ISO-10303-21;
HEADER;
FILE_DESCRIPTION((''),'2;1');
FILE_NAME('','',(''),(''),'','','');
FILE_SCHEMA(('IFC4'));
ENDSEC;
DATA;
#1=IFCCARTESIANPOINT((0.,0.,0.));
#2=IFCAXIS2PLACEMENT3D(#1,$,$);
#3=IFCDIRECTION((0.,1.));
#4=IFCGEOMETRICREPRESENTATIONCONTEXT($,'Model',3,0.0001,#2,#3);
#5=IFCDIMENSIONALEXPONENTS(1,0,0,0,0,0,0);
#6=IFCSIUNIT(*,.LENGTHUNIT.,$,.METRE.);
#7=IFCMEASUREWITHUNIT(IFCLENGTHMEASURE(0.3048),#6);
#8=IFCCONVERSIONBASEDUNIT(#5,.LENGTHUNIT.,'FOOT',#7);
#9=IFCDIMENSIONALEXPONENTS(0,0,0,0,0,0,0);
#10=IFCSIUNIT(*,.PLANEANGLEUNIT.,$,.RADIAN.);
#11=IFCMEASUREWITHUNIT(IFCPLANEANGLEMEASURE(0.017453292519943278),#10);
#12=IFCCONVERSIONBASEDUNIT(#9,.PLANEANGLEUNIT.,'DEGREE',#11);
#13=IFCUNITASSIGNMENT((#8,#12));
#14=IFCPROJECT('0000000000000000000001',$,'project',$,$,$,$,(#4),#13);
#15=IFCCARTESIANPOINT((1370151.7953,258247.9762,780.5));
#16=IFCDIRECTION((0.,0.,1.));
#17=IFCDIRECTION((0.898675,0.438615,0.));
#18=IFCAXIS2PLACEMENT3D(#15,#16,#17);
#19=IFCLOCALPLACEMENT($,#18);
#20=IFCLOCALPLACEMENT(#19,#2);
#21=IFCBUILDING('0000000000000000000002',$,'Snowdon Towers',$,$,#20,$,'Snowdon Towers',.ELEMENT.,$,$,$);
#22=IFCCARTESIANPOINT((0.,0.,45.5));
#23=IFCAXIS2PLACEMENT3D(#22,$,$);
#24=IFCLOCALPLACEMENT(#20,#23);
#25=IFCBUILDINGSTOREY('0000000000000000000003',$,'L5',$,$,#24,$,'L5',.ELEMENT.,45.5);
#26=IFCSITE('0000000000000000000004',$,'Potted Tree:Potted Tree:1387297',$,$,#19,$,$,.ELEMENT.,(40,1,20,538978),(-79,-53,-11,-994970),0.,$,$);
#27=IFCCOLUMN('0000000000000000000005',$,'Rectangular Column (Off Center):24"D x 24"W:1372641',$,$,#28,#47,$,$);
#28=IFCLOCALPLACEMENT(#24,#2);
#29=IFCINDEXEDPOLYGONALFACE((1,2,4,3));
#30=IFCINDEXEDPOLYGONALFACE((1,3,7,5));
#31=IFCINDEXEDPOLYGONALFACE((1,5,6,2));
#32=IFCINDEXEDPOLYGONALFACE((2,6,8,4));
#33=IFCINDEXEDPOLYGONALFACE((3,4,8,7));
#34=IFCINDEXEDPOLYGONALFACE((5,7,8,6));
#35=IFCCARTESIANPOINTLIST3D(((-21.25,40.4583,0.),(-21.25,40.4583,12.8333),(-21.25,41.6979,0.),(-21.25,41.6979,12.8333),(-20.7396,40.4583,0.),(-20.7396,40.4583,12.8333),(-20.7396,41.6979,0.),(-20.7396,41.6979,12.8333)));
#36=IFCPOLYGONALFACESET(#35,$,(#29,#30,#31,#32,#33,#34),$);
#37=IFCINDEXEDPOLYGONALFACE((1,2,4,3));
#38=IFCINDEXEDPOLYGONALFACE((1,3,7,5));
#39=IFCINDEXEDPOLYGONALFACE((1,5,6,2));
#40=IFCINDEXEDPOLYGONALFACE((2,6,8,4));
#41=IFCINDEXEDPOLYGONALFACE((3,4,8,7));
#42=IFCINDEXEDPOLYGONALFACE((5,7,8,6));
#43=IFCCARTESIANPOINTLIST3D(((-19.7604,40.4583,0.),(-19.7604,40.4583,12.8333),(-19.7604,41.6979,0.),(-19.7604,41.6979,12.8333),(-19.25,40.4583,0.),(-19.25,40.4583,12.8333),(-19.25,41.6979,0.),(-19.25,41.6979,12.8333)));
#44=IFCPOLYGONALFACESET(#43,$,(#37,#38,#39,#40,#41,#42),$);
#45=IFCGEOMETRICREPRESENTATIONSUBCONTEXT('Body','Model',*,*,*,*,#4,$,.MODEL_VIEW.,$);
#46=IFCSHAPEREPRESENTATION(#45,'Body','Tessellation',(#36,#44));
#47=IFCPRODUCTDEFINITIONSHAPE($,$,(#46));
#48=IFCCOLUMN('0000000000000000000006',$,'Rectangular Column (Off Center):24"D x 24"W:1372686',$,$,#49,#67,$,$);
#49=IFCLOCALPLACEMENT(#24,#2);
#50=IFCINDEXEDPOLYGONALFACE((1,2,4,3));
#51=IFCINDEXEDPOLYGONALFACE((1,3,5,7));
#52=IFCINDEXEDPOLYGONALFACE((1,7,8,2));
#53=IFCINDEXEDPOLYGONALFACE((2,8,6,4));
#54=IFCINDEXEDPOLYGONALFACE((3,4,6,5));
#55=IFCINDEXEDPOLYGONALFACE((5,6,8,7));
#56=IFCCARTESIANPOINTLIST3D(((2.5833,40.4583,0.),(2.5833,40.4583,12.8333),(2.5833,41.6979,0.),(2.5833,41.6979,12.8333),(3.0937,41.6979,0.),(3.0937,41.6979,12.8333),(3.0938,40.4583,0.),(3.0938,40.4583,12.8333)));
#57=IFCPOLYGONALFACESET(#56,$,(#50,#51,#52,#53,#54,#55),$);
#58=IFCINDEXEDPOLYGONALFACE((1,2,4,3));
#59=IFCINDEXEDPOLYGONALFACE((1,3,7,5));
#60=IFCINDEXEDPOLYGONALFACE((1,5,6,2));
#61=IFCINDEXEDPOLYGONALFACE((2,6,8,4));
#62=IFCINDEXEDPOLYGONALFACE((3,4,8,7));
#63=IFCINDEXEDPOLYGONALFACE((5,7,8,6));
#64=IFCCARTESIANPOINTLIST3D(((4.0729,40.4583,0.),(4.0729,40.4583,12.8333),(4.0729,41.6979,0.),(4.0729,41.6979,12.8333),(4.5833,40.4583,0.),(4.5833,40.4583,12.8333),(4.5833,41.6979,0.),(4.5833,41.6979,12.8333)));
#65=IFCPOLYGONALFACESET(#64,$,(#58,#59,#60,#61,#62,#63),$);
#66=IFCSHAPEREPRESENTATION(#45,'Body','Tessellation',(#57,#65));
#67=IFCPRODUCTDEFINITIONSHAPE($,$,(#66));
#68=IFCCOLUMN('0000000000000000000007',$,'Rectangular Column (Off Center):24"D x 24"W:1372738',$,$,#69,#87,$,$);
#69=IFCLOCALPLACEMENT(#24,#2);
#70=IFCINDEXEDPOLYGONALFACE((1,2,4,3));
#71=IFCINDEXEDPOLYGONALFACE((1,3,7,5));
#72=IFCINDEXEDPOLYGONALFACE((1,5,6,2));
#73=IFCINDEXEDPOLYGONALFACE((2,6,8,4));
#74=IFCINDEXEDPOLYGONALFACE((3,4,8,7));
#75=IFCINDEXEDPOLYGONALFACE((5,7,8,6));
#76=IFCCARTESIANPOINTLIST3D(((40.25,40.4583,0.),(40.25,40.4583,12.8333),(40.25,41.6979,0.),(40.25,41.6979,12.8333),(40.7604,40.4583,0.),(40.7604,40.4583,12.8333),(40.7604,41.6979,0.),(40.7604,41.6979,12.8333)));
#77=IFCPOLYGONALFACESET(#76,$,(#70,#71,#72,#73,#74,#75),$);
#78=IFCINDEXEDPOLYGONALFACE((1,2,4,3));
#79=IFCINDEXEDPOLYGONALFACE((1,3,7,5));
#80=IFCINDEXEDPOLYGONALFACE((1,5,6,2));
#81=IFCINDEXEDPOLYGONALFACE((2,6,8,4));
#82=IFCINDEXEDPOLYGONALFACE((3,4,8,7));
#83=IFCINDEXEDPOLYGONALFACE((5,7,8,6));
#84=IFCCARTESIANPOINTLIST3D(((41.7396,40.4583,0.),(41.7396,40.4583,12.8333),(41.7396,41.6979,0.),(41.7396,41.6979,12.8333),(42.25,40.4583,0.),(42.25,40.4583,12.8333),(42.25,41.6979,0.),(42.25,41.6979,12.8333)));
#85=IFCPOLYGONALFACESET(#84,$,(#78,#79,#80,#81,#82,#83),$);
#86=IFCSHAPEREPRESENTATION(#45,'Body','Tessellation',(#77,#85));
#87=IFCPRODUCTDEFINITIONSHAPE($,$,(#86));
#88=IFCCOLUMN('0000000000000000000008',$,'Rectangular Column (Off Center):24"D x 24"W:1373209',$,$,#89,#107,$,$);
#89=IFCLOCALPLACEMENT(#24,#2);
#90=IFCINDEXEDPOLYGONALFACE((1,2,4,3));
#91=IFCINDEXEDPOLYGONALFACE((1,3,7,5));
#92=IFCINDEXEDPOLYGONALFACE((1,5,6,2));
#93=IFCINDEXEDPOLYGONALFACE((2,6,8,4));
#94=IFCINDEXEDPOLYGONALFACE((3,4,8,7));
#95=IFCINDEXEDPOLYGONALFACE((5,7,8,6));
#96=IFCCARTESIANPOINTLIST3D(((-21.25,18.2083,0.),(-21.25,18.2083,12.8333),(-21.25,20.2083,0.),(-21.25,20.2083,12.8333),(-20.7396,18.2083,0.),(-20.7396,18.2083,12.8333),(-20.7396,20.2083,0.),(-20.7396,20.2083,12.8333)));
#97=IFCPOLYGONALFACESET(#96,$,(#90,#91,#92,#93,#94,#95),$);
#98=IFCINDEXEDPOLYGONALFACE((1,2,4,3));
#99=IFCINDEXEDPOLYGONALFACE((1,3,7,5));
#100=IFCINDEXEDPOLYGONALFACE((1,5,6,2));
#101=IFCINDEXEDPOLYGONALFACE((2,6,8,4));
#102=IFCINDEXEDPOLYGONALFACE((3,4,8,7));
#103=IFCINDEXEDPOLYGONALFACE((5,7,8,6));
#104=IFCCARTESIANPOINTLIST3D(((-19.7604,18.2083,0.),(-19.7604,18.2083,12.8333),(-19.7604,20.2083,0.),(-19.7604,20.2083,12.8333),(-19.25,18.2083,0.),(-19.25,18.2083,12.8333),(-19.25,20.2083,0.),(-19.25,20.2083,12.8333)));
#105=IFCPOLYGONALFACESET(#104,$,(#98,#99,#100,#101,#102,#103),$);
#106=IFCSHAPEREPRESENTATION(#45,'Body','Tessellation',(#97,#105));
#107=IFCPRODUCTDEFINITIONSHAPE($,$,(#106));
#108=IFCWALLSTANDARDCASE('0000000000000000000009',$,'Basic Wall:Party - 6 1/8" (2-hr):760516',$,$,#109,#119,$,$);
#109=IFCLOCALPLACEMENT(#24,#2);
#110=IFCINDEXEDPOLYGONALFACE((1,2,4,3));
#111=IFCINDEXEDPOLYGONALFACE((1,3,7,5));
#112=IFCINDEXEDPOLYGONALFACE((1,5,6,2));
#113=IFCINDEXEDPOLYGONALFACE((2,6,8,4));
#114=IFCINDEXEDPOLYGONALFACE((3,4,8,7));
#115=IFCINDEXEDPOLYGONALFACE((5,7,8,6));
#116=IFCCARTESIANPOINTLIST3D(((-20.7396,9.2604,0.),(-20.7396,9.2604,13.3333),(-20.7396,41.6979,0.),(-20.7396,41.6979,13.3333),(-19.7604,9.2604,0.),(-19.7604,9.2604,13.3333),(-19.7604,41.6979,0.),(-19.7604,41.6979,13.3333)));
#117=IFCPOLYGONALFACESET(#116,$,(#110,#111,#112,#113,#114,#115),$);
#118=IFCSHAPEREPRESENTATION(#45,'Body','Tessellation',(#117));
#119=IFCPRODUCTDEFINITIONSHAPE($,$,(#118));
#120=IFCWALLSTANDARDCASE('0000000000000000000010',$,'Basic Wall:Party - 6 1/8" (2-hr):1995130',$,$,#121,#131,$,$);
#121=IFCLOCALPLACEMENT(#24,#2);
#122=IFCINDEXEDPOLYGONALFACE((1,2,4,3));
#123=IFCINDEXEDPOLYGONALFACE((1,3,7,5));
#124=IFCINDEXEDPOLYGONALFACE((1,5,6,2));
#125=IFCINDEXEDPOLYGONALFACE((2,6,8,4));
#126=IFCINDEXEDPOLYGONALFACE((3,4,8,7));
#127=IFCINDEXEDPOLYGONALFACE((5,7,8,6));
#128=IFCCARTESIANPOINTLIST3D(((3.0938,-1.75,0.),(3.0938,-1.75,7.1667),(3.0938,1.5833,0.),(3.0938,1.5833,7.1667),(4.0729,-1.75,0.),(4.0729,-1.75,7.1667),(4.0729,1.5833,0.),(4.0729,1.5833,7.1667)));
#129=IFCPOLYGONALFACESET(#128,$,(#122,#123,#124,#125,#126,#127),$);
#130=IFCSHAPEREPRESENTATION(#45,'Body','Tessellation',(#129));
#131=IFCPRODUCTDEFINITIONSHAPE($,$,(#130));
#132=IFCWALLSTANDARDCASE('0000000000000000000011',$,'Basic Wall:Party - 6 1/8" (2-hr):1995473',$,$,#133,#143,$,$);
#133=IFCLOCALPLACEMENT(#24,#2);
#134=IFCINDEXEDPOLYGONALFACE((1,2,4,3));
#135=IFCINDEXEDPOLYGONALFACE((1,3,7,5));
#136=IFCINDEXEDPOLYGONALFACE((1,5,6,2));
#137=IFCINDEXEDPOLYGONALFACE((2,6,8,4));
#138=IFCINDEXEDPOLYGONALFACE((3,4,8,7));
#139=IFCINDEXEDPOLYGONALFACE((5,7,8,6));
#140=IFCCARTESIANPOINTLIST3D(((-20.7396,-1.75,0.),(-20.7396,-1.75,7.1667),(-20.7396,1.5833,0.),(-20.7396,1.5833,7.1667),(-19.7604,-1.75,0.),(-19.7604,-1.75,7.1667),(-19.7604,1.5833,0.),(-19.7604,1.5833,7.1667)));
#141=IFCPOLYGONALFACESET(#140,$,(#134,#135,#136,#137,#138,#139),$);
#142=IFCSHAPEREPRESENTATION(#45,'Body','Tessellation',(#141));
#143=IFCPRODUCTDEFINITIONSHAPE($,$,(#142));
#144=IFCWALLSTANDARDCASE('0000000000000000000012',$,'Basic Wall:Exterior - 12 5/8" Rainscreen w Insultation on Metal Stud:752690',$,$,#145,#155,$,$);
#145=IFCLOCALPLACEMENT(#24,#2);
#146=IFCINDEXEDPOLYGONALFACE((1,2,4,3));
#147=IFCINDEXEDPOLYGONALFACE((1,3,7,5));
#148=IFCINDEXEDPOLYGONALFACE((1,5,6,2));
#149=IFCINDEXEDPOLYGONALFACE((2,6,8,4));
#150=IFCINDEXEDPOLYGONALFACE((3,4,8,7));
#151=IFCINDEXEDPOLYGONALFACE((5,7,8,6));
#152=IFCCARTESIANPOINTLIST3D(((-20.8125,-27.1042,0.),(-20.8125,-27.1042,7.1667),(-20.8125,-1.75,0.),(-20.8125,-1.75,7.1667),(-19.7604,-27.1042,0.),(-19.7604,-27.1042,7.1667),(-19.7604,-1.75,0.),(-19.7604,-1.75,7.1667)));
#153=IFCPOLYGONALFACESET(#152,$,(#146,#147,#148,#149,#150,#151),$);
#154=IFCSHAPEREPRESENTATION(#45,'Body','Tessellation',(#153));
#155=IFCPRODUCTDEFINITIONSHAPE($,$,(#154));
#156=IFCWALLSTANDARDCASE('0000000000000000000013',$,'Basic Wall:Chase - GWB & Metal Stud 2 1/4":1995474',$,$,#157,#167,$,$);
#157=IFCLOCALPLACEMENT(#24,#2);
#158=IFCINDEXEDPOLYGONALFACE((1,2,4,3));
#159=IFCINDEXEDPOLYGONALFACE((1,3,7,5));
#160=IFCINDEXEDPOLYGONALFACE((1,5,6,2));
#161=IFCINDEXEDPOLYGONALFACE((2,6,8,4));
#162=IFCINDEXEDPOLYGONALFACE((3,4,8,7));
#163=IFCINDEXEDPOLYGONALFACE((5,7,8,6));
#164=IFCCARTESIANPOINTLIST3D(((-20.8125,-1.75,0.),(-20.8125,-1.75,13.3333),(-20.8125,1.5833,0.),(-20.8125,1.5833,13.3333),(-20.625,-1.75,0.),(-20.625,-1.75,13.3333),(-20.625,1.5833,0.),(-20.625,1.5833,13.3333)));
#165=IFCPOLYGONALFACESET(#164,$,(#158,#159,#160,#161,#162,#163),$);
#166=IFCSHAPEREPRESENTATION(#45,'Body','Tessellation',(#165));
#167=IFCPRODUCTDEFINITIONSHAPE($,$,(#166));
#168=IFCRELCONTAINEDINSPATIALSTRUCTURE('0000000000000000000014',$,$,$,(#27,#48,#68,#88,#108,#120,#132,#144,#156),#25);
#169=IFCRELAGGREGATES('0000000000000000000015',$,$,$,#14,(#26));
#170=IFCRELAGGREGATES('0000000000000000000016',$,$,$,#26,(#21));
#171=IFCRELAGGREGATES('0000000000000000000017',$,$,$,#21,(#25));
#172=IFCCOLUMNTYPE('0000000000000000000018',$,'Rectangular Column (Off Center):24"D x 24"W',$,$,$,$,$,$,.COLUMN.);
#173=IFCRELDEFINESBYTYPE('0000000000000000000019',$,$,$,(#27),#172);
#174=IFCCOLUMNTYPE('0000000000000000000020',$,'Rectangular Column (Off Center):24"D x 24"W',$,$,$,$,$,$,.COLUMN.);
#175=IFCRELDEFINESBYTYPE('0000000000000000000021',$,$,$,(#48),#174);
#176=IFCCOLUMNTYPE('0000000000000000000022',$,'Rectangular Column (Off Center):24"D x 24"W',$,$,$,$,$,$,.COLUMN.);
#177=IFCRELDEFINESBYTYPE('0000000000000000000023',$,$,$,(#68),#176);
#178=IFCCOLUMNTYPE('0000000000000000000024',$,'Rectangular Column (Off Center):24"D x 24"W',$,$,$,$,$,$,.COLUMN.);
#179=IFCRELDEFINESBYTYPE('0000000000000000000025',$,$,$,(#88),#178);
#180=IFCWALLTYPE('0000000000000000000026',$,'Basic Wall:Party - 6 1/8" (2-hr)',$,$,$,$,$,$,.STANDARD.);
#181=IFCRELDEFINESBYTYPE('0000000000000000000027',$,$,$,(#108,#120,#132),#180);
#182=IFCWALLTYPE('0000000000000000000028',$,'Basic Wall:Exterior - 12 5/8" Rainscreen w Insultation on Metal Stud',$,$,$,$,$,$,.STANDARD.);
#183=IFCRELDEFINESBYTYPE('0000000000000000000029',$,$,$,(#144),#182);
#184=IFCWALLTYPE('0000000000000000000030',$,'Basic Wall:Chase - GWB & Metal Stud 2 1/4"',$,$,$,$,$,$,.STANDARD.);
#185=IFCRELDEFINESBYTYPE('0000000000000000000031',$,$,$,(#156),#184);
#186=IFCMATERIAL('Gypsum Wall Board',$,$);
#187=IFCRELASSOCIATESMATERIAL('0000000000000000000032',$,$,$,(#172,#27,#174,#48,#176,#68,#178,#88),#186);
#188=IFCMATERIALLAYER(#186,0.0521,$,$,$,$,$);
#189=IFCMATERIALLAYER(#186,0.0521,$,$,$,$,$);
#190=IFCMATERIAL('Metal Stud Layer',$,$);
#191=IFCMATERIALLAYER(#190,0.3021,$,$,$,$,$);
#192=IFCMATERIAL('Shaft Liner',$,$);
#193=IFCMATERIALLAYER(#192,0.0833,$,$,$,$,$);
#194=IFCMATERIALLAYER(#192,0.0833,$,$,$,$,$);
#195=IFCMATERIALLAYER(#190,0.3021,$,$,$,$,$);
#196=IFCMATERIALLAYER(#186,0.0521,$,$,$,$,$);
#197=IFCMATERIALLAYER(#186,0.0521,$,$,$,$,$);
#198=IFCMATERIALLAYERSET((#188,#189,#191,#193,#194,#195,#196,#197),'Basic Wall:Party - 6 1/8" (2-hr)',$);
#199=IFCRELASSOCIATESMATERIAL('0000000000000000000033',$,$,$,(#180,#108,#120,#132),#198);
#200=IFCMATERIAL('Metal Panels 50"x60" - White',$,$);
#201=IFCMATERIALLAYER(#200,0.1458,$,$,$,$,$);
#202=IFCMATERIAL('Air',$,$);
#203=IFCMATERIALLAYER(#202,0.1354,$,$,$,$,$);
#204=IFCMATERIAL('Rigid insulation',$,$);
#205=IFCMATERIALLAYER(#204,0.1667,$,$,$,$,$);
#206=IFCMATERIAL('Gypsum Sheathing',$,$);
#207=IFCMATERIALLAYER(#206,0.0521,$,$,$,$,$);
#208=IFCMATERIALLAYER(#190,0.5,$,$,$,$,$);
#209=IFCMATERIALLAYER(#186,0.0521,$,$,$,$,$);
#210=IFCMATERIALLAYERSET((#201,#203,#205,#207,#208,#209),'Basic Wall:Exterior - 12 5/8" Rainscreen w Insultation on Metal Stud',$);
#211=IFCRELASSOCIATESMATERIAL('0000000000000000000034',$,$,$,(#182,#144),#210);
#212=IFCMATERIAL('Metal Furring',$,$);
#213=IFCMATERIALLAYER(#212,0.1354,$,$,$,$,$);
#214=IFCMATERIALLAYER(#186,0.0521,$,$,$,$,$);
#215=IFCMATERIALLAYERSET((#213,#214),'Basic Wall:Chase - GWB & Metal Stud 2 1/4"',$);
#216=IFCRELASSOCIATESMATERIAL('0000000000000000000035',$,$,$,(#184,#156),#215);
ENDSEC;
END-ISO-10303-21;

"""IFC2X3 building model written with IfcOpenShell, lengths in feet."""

from ifc_helpers import new_model, entity, si_unit, converted_unit, direction, frame, frame_2d, origin, place, context, subcontext, project, spatial, rectangle, extrude, source, transform, mapped, material, layer, layer_set, layer_usage, type_object, type_shapes, element, save


model = new_model("IFC2X3")

# Units and contexts
model_context = context("Model", 3, precision=0.0001, world=origin(), true_north=direction((0.0, 1.0)))
body_context = subcontext(model_context, "Body", "Model", "MODEL_VIEW")
ifc_project = project(units=[converted_unit("LENGTHUNIT", "FOOT", entity("IfcLengthMeasure", 0.3048), si_unit("LENGTHUNIT", "METRE"), dimensions=[1, 0, 0, 0, 0, 0, 0]), converted_unit("PLANEANGLEUNIT", "DEGREE", entity("IfcPlaneAngleMeasure", 0.017453292519943278), si_unit("PLANEANGLEUNIT", "RADIAN"), dimensions=[0, 0, 0, 0, 0, 0, 0])], contexts=[model_context])

# Site, building, storey
site_placement = place(None, frame((1370151.7953, 258247.9762, 780.5), z_axis=(0.0, 0.0, 1.0), x_axis=(0.898675, 0.438615, 0.0)))
site = spatial("IfcSite", under=ifc_project, at=site_placement, Name="Potted Tree:Potted Tree:1387297", CompositionType="ELEMENT", RefLatitude=(40, 1, 20, 538978), RefLongitude=(-79, -53, -11, -994970), RefElevation=0.0)
building_placement = place(site_placement, origin())
building = spatial("IfcBuilding", under=site, at=building_placement, Name="Snowdon Towers", LongName="Snowdon Towers", CompositionType="ELEMENT")
storey_placement = place(building_placement, frame((0.0, 0.0, 45.5)))
storey = spatial("IfcBuildingStorey", under=building, at=storey_placement, Name="L5", LongName="L5", CompositionType="ELEMENT", Elevation=45.5)

# Shared definitions
ifc_material_1 = material(Name="Gypsum Wall Board")

# Columns
column_type_1 = type_object("IfcColumnType", Name="Rectangular Column (Off Center):24\"D x 24\"W", PredefinedType="COLUMN", material=ifc_material_1)
shared_shape_1 = source(origin(), body_context, "Body", "SweptSolid", [
    extrude(rectangle(XDim=1.2396, YDim=0.5104, at=frame_2d((0.0, 0.0), x_axis=(1.0, 0.0))), frame((-20.9948, 41.0781, 45.5), z_axis=(0.0, 0.0, 1.0), x_axis=(0.0, 1.0, 0.0)), (0.0, 0.0, 1.0), 12.8333),
    extrude(rectangle(XDim=1.2396, YDim=0.5104, at=frame_2d((0.0, 0.0), x_axis=(1.0, 0.0))), frame((-19.5052, 41.0781, 45.5), z_axis=(0.0, 0.0, 1.0), x_axis=(0.0, 1.0, 0.0)), (0.0, 0.0, 1.0), 12.8333),
])
type_shapes(column_type_1, [shared_shape_1])
column_1_placement = place(storey_placement, frame((0.0, 0.0, -45.5)))
element("IfcColumn", 1, at=column_1_placement, inside=storey, type_object=column_type_1, material=ifc_material_1, Name="Rectangular Column (Off Center):24\"D x 24\"W:1372641", context=body_context, shape_type="MappedRepresentation", body=[
    mapped(shared_shape_1, transform((0.0, 0.0, 0.0), scale=1.0)),
])
column_type_2 = type_object("IfcColumnType", Name="Rectangular Column (Off Center):24\"D x 24\"W", PredefinedType="COLUMN", material=ifc_material_1)
shared_shape_2 = source(origin(), body_context, "Body", "SweptSolid", [
    extrude(rectangle(XDim=0.5104, YDim=1.2396, at=frame_2d((0.0, 0.0), x_axis=(1.0, 0.0))), frame((2.8385, 41.0781, 45.5)), (0.0, 0.0, 1.0), 12.8333),
    extrude(rectangle(XDim=0.5104, YDim=1.2396, at=frame_2d((0.0, 0.0), x_axis=(1.0, 0.0))), frame((4.3281, 41.0781, 45.5), z_axis=(0.0, 0.0, 1.0), x_axis=(-1.0, 0.0, 0.0)), (0.0, 0.0, 1.0), 12.8333),
])
type_shapes(column_type_2, [shared_shape_2])
column_2_placement = place(storey_placement, frame((0.0, 0.0, -45.5)))
element("IfcColumn", 2, at=column_2_placement, inside=storey, type_object=column_type_2, material=ifc_material_1, Name="Rectangular Column (Off Center):24\"D x 24\"W:1372686", context=body_context, shape_type="MappedRepresentation", body=[
    mapped(shared_shape_2, transform((0.0, 0.0, 0.0), scale=1.0)),
])
column_type_3 = type_object("IfcColumnType", Name="Rectangular Column (Off Center):24\"D x 24\"W", PredefinedType="COLUMN", material=ifc_material_1)
shared_shape_3 = source(origin(), body_context, "Body", "SweptSolid", [
    extrude(rectangle(XDim=1.2396, YDim=0.5104, at=frame_2d((0.0, 0.0), x_axis=(1.0, 0.0))), frame((40.5052, 41.0781, 45.5), z_axis=(0.0, 0.0, 1.0), x_axis=(0.0, 1.0, 0.0)), (0.0, 0.0, 1.0), 12.8333),
    extrude(rectangle(XDim=1.2396, YDim=0.5104, at=frame_2d((0.0, 0.0), x_axis=(1.0, 0.0))), frame((41.9948, 41.0781, 45.5), z_axis=(0.0, 0.0, 1.0), x_axis=(0.0, 1.0, 0.0)), (0.0, 0.0, 1.0), 12.8333),
])
type_shapes(column_type_3, [shared_shape_3])
column_3_placement = place(storey_placement, frame((0.0, 0.0, -45.5)))
element("IfcColumn", 3, at=column_3_placement, inside=storey, type_object=column_type_3, material=ifc_material_1, Name="Rectangular Column (Off Center):24\"D x 24\"W:1372738", context=body_context, shape_type="MappedRepresentation", body=[
    mapped(shared_shape_3, transform((0.0, 0.0, 0.0), scale=1.0)),
])
column_type_4 = type_object("IfcColumnType", Name="Rectangular Column (Off Center):24\"D x 24\"W", PredefinedType="COLUMN", material=ifc_material_1)
shared_shape_4 = source(origin(), body_context, "Body", "SweptSolid", [
    extrude(rectangle(XDim=0.5104, YDim=2.0, at=frame_2d((0.0, 0.0), x_axis=(1.0, 0.0))), frame((-20.9948, 19.2083, 45.5)), (0.0, 0.0, 1.0), 12.8333),
    extrude(rectangle(XDim=0.5104, YDim=2.0, at=frame_2d((0.0, 0.0), x_axis=(1.0, 0.0))), frame((-19.5052, 19.2083, 45.5), z_axis=(0.0, 0.0, 1.0), x_axis=(-1.0, 0.0, 0.0)), (0.0, 0.0, 1.0), 12.8333),
])
type_shapes(column_type_4, [shared_shape_4])
column_4_placement = place(storey_placement, frame((0.0, 0.0, -45.5)))
element("IfcColumn", 4, at=column_4_placement, inside=storey, type_object=column_type_4, material=ifc_material_1, Name="Rectangular Column (Off Center):24\"D x 24\"W:1373209", context=body_context, shape_type="MappedRepresentation", body=[
    mapped(shared_shape_4, transform((0.0, 0.0, 0.0), scale=1.0)),
])

# Walls
ifc_layer_1 = layer(ifc_material_1, 0.0521)
ifc_layer_2 = layer(ifc_material_1, 0.0521)
ifc_material_2 = material(Name="Metal Stud Layer")
ifc_layer_3 = layer(ifc_material_2, 0.3021)
ifc_material_3 = material(Name="Shaft Liner")
ifc_layer_4 = layer(ifc_material_3, 0.0833)
ifc_layer_5 = layer(ifc_material_3, 0.0833)
ifc_layer_6 = layer(ifc_material_2, 0.3021)
ifc_layer_7 = layer(ifc_material_1, 0.0521)
ifc_layer_8 = layer(ifc_material_1, 0.0521)
ifc_layer_set_1 = layer_set([ifc_layer_1, ifc_layer_2, ifc_layer_3, ifc_layer_4, ifc_layer_5, ifc_layer_6, ifc_layer_7, ifc_layer_8], Name="Basic Wall:Party - 6 1/8\" (2-hr)")
ifc_layer_usage_1 = layer_usage(ifc_layer_set_1, "AXIS2", "NEGATIVE", 0.4896)
wall_type_1 = type_object("IfcWallType", Name="Basic Wall:Party - 6 1/8\" (2-hr)", PredefinedType="STANDARD", material=ifc_layer_set_1)
wall_1_placement = place(storey_placement, frame((-20.25, 9.2604, 0.0), z_axis=(0.0, 0.0, 1.0), x_axis=(0.0, 1.0, 0.0)))
element("IfcWallStandardCase", 5, at=wall_1_placement, inside=storey, type_object=wall_type_1, material=ifc_layer_usage_1, Name="Basic Wall:Party - 6 1/8\" (2-hr):760516", context=body_context, shape_type="SweptSolid", body=[
    extrude(rectangle(XDim=32.4375, YDim=0.9792, at=frame_2d((16.2188, 0.0), x_axis=(-1.0, 0.0))), origin(), (0.0, 0.0, 1.0), 13.3333),
])
ifc_layer_usage_2 = layer_usage(ifc_layer_set_1, "AXIS2", "POSITIVE", -0.4896)
wall_2_placement = place(storey_placement, frame((3.5833, -1.75, 0.0), z_axis=(0.0, 0.0, 1.0), x_axis=(0.0, 1.0, 0.0)))
element("IfcWallStandardCase", 6, at=wall_2_placement, inside=storey, type_object=wall_type_1, material=ifc_layer_usage_2, Name="Basic Wall:Party - 6 1/8\" (2-hr):1995130", context=body_context, shape_type="SweptSolid", body=[
    extrude(rectangle(XDim=3.3333, YDim=0.9792, at=frame_2d((1.6667, 0.0), x_axis=(-1.0, 0.0))), origin(), (0.0, 0.0, 1.0), 7.1667),
])
ifc_layer_usage_3 = layer_usage(ifc_layer_set_1, "AXIS2", "NEGATIVE", 0.4896)
wall_3_placement = place(storey_placement, frame((-20.25, -1.75, 0.0), z_axis=(0.0, 0.0, 1.0), x_axis=(0.0, 1.0, 0.0)))
element("IfcWallStandardCase", 7, at=wall_3_placement, inside=storey, type_object=wall_type_1, material=ifc_layer_usage_3, Name="Basic Wall:Party - 6 1/8\" (2-hr):1995473", context=body_context, shape_type="SweptSolid", body=[
    extrude(rectangle(XDim=3.3333, YDim=0.9792, at=frame_2d((1.6667, 0.0), x_axis=(-1.0, 0.0))), origin(), (0.0, 0.0, 1.0), 7.1667),
])
ifc_material_4 = material(Name="Metal Panels 50\"x60\" - White")
ifc_layer_9 = layer(ifc_material_4, 0.1458)
ifc_material_5 = material(Name="Air")
ifc_layer_10 = layer(ifc_material_5, 0.1354)
ifc_material_6 = material(Name="Rigid insulation")
ifc_layer_11 = layer(ifc_material_6, 0.1667)
ifc_material_7 = material(Name="Gypsum Sheathing")
ifc_layer_12 = layer(ifc_material_7, 0.0521)
ifc_layer_13 = layer(ifc_material_2, 0.5)
ifc_layer_14 = layer(ifc_material_1, 0.0521)
ifc_layer_set_2 = layer_set([ifc_layer_9, ifc_layer_10, ifc_layer_11, ifc_layer_12, ifc_layer_13, ifc_layer_14], Name="Basic Wall:Exterior - 12 5/8\" Rainscreen w Insultation on Metal Stud")
ifc_layer_usage_4 = layer_usage(ifc_layer_set_2, "AXIS2", "NEGATIVE", 0.526)
wall_type_2 = type_object("IfcWallType", Name="Basic Wall:Exterior - 12 5/8\" Rainscreen w Insultation on Metal Stud", PredefinedType="STANDARD", material=ifc_layer_set_2)
wall_4_placement = place(storey_placement, frame((-20.2865, -27.1042, 0.0), z_axis=(0.0, 0.0, 1.0), x_axis=(0.0, 1.0, 0.0)))
element("IfcWallStandardCase", 8, at=wall_4_placement, inside=storey, type_object=wall_type_2, material=ifc_layer_usage_4, Name="Basic Wall:Exterior - 12 5/8\" Rainscreen w Insultation on Metal Stud:752690", context=body_context, shape_type="SweptSolid", body=[
    extrude(rectangle(XDim=25.3542, YDim=1.0521, at=frame_2d((12.6771, 0.0), x_axis=(-1.0, 0.0))), origin(), (0.0, 0.0, 1.0), 7.1667),
])
ifc_material_8 = material(Name="Metal Furring")
ifc_layer_15 = layer(ifc_material_8, 0.1354)
ifc_layer_16 = layer(ifc_material_1, 0.0521)
ifc_layer_set_3 = layer_set([ifc_layer_15, ifc_layer_16], Name="Basic Wall:Chase - GWB & Metal Stud 2 1/4\"")
ifc_layer_usage_5 = layer_usage(ifc_layer_set_3, "AXIS2", "POSITIVE", -0.0938)
wall_type_3 = type_object("IfcWallType", Name="Basic Wall:Chase - GWB & Metal Stud 2 1/4\"", PredefinedType="STANDARD", material=ifc_layer_set_3)
wall_5_placement = place(storey_placement, frame((-20.7187, -1.75, 0.0), z_axis=(0.0, 0.0, 1.0), x_axis=(0.0, 1.0, 0.0)))
element("IfcWallStandardCase", 9, at=wall_5_placement, inside=storey, type_object=wall_type_3, material=ifc_layer_usage_5, Name="Basic Wall:Chase - GWB & Metal Stud 2 1/4\":1995474", context=body_context, shape_type="SweptSolid", body=[
    extrude(rectangle(XDim=3.3333, YDim=0.1875, at=frame_2d((1.6667, 0.0), x_axis=(-1.0, 0.0))), origin(), (0.0, 0.0, 1.0), 13.3333),
])

save(model, "model.ifc")
